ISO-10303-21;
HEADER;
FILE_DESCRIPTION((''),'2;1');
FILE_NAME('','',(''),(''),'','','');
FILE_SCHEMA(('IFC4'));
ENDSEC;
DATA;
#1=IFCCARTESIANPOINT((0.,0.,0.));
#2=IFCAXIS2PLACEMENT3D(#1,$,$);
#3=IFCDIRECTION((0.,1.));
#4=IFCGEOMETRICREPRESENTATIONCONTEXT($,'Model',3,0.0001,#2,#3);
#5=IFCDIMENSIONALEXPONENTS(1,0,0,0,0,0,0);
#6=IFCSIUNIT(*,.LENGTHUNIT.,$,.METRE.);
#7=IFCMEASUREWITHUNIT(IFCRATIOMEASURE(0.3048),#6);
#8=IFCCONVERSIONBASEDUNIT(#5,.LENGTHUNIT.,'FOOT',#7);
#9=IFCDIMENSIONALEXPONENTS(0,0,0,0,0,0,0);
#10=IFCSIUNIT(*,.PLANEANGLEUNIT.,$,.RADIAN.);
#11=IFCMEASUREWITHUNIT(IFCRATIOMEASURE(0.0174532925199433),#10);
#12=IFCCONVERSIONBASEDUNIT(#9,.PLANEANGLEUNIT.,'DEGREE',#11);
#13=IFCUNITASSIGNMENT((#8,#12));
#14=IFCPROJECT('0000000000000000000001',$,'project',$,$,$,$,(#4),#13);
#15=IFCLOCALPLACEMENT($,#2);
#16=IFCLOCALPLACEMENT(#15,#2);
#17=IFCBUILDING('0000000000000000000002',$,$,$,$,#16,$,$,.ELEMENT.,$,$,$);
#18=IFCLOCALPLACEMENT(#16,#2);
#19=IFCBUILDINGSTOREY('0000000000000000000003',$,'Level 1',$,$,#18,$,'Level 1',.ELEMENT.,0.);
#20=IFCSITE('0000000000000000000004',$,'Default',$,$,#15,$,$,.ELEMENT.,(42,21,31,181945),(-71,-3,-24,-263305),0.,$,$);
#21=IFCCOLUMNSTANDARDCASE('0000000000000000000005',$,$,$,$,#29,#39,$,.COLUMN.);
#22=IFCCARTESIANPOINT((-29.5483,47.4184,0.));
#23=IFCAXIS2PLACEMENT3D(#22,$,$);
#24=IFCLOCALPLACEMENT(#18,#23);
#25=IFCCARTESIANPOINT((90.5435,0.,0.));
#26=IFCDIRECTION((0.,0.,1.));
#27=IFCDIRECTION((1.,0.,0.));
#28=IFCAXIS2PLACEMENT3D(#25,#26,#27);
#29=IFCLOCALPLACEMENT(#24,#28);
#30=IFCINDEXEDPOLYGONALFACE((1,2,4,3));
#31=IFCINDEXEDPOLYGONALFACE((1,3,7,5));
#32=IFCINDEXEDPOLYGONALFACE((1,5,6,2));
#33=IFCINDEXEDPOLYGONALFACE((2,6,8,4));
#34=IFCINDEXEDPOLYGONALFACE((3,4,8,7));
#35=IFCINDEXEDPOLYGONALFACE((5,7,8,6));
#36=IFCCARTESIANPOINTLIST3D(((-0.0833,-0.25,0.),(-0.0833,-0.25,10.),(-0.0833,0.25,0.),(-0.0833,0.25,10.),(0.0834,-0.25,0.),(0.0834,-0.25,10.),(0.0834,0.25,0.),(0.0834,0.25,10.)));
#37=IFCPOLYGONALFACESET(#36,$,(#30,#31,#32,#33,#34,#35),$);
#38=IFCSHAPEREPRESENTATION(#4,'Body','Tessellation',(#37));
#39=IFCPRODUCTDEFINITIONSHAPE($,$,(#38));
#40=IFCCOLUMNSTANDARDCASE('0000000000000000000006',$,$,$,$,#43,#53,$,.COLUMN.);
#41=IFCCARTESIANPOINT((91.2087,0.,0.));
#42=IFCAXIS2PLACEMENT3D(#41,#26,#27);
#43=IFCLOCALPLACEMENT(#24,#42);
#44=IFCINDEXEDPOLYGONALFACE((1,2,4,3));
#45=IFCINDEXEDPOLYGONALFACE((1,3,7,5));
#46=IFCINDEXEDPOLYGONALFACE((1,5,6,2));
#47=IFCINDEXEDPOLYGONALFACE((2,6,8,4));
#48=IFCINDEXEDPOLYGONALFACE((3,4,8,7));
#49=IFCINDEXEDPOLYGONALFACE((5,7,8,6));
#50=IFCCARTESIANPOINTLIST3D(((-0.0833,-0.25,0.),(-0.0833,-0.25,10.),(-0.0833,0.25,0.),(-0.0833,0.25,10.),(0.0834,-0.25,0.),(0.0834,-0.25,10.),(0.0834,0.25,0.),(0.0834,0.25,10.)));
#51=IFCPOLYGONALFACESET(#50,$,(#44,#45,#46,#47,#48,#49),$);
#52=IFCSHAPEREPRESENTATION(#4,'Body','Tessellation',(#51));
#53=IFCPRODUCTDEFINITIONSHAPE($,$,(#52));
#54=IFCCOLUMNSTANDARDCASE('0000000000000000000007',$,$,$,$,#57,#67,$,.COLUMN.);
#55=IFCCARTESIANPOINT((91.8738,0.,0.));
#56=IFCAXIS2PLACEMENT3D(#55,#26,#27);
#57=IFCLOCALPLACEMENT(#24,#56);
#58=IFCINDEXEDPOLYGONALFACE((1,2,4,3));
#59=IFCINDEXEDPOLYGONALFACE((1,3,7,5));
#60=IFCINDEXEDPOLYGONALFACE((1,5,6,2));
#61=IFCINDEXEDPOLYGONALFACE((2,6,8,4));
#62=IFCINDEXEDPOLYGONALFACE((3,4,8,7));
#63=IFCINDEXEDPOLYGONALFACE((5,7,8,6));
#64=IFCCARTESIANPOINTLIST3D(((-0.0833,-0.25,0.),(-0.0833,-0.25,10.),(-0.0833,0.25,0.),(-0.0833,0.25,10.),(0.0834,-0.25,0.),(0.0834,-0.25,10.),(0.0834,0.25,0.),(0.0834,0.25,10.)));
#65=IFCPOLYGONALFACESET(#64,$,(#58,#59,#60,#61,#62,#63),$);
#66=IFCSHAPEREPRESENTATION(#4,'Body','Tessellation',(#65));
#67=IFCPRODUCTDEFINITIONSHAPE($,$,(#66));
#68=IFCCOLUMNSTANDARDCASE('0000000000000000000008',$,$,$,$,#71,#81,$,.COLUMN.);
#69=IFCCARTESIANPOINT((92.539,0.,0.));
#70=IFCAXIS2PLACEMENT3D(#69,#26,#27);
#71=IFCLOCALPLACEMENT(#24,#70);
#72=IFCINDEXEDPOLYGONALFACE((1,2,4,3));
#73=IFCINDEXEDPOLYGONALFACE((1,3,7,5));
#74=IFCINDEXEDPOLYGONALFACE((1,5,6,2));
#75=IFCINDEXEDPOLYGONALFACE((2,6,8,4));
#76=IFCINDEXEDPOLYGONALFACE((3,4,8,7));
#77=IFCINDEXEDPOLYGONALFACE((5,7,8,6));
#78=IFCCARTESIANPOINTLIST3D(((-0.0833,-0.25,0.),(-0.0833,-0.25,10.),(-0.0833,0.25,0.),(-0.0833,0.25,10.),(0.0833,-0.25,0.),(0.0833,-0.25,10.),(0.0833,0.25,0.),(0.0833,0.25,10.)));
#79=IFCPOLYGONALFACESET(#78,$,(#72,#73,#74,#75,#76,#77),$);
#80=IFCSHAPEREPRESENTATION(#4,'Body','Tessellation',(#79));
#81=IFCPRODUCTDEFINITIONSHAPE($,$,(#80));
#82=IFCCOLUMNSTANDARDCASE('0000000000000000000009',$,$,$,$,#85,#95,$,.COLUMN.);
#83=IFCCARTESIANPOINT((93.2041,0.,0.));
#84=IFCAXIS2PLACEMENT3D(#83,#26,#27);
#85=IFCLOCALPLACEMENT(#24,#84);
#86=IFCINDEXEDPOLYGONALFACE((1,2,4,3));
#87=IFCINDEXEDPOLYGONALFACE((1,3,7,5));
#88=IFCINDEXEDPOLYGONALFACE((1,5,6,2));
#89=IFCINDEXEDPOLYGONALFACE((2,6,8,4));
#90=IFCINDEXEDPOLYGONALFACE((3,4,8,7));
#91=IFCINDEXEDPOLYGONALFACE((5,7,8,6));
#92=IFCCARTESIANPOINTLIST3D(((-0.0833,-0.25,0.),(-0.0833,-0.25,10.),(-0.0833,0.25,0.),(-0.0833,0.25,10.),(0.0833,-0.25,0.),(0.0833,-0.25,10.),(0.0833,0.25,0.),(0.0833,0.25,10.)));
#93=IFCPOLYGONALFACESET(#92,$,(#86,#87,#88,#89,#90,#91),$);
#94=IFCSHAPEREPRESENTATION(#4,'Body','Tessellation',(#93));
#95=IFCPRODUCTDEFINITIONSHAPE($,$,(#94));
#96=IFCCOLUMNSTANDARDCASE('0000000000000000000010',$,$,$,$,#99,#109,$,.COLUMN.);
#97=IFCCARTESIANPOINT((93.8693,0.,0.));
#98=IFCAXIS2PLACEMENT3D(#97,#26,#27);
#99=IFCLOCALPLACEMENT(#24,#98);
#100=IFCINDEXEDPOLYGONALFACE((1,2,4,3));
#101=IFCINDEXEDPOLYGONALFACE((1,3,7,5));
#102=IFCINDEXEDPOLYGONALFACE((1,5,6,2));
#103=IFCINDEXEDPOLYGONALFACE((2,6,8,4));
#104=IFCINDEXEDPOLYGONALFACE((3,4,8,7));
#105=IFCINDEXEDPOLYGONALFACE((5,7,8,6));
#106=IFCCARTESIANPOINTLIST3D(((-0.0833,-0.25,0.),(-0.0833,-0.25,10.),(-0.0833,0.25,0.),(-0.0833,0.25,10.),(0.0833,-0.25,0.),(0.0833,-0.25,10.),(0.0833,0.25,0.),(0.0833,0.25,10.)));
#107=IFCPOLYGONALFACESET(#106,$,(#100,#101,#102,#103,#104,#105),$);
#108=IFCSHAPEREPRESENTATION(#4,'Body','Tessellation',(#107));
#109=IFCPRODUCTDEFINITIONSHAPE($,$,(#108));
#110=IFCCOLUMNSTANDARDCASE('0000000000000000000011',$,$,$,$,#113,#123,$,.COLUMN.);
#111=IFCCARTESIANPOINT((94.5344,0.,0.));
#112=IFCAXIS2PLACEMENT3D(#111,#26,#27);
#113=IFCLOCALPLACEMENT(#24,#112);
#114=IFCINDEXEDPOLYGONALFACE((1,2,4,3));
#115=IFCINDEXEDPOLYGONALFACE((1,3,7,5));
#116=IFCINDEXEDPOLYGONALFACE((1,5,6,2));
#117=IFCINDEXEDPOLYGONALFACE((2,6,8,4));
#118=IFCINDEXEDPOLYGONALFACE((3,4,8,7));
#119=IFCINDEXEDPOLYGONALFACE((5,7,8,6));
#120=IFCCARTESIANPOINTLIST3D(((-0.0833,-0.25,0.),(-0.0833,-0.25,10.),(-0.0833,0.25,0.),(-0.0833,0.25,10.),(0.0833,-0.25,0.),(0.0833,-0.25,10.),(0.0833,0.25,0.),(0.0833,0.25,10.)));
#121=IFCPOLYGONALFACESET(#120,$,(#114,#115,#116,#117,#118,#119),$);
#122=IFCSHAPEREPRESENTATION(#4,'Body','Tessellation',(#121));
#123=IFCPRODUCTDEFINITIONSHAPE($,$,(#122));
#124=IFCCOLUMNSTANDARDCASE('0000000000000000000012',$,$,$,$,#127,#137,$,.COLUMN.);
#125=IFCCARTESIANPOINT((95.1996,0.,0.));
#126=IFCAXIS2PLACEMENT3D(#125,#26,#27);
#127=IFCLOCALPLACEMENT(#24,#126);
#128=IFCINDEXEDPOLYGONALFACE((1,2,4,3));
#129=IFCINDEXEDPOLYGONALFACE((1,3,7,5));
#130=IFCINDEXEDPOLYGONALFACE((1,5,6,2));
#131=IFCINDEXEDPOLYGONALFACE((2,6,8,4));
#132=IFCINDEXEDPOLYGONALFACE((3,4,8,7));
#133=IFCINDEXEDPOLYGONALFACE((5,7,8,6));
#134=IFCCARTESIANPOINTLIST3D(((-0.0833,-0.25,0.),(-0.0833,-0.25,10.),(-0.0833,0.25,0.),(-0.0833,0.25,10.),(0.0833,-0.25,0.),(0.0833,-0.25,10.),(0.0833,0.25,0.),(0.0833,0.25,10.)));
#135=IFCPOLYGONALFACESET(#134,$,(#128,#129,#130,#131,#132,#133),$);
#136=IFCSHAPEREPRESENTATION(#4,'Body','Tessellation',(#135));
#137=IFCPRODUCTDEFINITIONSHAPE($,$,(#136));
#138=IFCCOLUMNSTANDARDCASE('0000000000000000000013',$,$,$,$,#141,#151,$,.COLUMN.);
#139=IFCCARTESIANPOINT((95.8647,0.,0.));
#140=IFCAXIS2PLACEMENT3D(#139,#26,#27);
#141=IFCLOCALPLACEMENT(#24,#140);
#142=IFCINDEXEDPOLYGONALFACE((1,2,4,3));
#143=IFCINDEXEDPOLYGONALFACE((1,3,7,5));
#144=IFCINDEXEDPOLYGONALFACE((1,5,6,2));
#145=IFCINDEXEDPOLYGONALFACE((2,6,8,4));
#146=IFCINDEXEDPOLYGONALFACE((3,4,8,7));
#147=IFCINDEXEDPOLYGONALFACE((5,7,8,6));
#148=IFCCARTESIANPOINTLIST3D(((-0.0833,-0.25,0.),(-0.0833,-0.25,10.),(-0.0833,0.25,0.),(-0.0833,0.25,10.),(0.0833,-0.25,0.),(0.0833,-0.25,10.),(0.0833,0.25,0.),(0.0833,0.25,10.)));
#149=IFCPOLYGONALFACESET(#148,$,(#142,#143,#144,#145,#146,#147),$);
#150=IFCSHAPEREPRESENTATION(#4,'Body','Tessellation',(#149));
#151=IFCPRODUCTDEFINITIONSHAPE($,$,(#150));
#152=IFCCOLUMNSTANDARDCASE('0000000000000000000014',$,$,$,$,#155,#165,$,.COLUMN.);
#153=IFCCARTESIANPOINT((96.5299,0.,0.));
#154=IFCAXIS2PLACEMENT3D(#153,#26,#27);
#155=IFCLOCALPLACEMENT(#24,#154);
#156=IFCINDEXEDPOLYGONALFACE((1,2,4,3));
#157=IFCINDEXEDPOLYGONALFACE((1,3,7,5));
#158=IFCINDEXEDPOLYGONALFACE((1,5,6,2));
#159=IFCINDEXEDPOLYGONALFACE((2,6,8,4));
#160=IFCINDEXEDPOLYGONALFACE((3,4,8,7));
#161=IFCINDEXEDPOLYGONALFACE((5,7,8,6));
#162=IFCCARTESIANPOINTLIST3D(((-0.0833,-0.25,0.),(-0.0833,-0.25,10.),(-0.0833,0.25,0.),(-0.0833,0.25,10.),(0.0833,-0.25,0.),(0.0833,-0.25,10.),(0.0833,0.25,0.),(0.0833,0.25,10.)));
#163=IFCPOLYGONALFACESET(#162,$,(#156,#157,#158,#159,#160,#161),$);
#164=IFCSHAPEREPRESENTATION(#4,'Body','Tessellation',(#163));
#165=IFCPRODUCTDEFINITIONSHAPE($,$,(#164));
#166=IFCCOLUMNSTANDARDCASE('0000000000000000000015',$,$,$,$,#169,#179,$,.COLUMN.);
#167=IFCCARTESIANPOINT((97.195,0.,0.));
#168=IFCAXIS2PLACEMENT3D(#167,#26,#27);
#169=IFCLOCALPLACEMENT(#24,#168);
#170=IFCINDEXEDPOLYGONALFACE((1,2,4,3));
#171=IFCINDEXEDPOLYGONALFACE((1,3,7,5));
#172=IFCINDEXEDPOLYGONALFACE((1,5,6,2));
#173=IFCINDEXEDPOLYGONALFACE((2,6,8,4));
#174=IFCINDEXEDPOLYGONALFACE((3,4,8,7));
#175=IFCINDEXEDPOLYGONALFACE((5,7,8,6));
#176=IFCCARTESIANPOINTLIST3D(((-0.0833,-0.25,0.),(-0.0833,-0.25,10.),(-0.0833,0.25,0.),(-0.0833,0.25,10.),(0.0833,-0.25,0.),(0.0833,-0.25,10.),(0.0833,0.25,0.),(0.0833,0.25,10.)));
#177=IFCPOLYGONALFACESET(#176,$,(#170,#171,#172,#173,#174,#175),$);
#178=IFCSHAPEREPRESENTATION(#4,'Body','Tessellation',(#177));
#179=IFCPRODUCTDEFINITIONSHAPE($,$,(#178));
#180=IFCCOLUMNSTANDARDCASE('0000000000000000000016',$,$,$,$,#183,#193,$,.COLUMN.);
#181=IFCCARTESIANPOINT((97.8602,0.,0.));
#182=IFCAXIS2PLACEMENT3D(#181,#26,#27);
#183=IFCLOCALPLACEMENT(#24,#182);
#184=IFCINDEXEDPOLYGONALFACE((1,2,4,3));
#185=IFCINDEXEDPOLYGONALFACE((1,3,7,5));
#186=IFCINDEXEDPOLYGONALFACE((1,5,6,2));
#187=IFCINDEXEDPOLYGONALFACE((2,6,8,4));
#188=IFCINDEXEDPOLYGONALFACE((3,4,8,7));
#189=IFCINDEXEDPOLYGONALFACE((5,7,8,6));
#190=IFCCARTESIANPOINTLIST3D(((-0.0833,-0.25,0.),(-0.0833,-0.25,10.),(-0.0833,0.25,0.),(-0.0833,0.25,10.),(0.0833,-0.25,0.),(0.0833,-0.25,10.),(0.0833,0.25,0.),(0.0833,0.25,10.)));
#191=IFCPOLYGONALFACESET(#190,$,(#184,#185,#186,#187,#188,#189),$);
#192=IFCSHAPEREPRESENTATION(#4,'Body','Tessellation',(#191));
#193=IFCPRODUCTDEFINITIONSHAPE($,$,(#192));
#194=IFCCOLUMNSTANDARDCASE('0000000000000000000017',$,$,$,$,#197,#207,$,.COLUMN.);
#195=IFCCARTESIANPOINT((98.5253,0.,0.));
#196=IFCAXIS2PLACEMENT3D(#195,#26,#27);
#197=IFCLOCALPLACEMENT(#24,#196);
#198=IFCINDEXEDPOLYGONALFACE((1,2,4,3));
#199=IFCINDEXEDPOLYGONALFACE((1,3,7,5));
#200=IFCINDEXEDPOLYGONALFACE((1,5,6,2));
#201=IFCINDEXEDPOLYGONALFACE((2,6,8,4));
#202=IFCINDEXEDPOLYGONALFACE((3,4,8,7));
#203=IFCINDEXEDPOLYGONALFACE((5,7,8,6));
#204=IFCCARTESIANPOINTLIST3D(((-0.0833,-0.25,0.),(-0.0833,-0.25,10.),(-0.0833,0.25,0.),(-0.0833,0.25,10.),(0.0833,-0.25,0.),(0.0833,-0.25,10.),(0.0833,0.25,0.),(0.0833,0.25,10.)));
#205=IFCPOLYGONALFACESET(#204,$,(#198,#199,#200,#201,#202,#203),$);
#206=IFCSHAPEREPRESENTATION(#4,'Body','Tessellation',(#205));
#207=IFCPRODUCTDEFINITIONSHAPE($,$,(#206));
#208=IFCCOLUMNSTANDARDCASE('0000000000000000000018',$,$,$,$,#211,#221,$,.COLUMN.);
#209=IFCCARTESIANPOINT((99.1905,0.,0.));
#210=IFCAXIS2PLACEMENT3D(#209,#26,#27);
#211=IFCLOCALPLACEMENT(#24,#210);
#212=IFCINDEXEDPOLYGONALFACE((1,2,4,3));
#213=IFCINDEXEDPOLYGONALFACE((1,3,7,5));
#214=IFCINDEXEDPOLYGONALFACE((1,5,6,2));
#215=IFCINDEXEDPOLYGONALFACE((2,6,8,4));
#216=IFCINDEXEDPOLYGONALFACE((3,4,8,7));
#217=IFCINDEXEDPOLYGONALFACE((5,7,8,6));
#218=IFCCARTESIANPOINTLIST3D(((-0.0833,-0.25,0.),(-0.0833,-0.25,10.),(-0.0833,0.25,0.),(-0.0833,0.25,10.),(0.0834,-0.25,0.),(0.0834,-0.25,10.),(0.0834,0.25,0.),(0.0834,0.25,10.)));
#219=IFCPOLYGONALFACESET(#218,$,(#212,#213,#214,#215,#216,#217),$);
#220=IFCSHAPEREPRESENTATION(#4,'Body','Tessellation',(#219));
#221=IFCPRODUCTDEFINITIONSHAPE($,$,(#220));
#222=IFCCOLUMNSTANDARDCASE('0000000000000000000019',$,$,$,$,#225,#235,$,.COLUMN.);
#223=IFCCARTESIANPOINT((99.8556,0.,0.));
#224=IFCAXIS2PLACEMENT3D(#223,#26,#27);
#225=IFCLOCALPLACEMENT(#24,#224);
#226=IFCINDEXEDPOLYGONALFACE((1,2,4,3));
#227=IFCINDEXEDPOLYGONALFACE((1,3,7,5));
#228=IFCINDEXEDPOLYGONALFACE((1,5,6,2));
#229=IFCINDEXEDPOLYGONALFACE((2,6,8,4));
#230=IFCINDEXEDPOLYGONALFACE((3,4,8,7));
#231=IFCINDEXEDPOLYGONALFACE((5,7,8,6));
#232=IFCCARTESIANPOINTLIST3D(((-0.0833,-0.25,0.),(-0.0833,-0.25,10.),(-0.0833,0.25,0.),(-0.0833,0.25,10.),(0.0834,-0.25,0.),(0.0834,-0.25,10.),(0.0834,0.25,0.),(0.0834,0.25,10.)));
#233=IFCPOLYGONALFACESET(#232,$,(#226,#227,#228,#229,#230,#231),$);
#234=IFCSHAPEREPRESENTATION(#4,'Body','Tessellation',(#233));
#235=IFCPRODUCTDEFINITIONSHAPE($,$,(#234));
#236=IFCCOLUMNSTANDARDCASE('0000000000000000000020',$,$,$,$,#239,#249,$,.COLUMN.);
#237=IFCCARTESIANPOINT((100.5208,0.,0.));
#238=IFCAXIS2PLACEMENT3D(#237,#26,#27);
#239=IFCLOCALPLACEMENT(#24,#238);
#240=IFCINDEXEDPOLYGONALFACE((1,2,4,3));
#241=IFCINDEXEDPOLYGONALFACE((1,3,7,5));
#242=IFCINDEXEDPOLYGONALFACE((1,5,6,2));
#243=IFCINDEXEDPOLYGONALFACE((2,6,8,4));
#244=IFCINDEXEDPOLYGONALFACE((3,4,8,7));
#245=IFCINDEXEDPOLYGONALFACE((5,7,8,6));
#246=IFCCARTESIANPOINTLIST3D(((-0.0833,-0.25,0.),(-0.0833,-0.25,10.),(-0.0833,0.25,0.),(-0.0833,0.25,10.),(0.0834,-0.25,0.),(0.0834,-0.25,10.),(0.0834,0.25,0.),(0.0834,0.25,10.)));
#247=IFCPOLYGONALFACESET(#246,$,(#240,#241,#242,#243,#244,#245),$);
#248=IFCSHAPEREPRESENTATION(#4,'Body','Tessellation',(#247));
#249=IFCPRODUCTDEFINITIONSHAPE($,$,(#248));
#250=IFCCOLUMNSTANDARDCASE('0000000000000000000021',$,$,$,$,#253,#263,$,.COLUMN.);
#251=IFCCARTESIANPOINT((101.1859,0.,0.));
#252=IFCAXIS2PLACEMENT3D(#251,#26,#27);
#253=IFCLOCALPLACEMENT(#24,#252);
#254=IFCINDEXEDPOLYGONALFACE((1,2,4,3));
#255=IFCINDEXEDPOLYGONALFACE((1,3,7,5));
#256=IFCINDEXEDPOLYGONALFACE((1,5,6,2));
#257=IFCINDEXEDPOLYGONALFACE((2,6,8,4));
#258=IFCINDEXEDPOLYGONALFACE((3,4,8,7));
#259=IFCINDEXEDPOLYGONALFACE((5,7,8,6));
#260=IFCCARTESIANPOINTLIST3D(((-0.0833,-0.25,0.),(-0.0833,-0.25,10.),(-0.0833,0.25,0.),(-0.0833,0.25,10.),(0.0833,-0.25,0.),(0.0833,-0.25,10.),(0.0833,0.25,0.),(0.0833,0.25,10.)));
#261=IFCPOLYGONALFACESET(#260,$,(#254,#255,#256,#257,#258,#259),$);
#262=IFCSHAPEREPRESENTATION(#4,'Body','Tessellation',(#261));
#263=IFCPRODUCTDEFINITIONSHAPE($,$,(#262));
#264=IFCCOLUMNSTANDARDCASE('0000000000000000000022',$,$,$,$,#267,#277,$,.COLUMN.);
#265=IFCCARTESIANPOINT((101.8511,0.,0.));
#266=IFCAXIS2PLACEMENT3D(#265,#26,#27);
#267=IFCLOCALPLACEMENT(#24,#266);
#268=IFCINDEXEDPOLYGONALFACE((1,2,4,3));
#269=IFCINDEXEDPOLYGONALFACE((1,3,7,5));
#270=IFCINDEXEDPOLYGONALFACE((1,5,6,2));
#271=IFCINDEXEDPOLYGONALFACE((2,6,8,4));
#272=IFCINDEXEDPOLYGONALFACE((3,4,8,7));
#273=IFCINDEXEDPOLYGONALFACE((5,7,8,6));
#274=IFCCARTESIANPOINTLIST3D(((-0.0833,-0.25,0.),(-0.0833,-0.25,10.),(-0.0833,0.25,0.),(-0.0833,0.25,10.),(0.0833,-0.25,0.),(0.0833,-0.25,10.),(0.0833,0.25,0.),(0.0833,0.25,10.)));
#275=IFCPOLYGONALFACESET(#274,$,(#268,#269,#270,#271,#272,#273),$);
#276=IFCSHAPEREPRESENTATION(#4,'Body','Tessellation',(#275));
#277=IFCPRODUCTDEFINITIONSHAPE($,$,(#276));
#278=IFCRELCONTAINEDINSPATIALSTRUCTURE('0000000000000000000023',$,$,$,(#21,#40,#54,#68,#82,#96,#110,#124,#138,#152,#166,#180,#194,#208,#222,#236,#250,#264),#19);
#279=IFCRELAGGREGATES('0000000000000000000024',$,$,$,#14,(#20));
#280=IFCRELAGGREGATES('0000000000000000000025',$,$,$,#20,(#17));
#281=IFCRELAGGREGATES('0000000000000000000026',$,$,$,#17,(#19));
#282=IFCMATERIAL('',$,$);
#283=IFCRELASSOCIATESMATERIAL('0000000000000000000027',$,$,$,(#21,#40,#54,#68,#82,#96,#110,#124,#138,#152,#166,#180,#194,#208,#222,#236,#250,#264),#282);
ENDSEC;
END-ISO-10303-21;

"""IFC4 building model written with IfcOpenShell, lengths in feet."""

from ifc_helpers import new_model, entity, si_unit, converted_unit, direction, frame, origin, place, context, project, spatial, rectangle, extrude, material, element, save


model = new_model("IFC4")

# Units and contexts
model_context = context("Model", 3, precision=0.0001, world=origin(), true_north=direction((0.0, 1.0)))
ifc_project = project(units=[converted_unit("LENGTHUNIT", "FOOT", entity("IfcRatioMeasure", 0.3048), si_unit("LENGTHUNIT", "METRE"), dimensions=[1, 0, 0, 0, 0, 0, 0]), converted_unit("PLANEANGLEUNIT", "DEGREE", entity("IfcRatioMeasure", 0.0174532925199433), si_unit("PLANEANGLEUNIT", "RADIAN"), dimensions=[0, 0, 0, 0, 0, 0, 0])], contexts=[model_context])

# Site, building, storey
site_placement = place(None, origin())
site = spatial("IfcSite", under=ifc_project, at=site_placement, Name="Default", CompositionType="ELEMENT", RefLatitude=(42, 21, 31, 181945), RefLongitude=(-71, -3, -24, -263305), RefElevation=0.0)
building_placement = place(site_placement, origin())
building = spatial("IfcBuilding", under=site, at=building_placement, CompositionType="ELEMENT")
storey_placement = place(building_placement, origin())
storey = spatial("IfcBuildingStorey", under=building, at=storey_placement, Name="Level 1", LongName="Level 1", CompositionType="ELEMENT", Elevation=0.0)

# Columns
ifc_material_1 = material(Name="")
placement = place(storey_placement, frame((-29.5483, 47.4184, 0.0)))
for number, where, z_axis, x_axis in (
    (1, (90.5435, 0.0, 0.0), (0.0, 0.0, 1.0), (1.0, 0.0, 0.0)),
    (2, (91.2087, 0.0, 0.0), (0.0, 0.0, 1.0), (1.0, 0.0, 0.0)),
    (3, (91.8738, 0.0, 0.0), (0.0, 0.0, 1.0), (1.0, 0.0, 0.0)),
    (4, (92.539, 0.0, 0.0), (0.0, 0.0, 1.0), (1.0, 0.0, 0.0)),
    (5, (93.2041, 0.0, 0.0), (0.0, 0.0, 1.0), (1.0, 0.0, 0.0)),
    (6, (93.8693, 0.0, 0.0), (0.0, 0.0, 1.0), (1.0, 0.0, 0.0)),
    (7, (94.5344, 0.0, 0.0), (0.0, 0.0, 1.0), (1.0, 0.0, 0.0)),
    (8, (95.1996, 0.0, 0.0), (0.0, 0.0, 1.0), (1.0, 0.0, 0.0)),
    (9, (95.8647, 0.0, 0.0), (0.0, 0.0, 1.0), (1.0, 0.0, 0.0)),
    (10, (96.5299, 0.0, 0.0), (0.0, 0.0, 1.0), (1.0, 0.0, 0.0)),
    (11, (97.195, 0.0, 0.0), (0.0, 0.0, 1.0), (1.0, 0.0, 0.0)),
    (12, (97.8602, 0.0, 0.0), (0.0, 0.0, 1.0), (1.0, 0.0, 0.0)),
    (13, (98.5253, 0.0, 0.0), (0.0, 0.0, 1.0), (1.0, 0.0, 0.0)),
    (14, (99.1905, 0.0, 0.0), (0.0, 0.0, 1.0), (1.0, 0.0, 0.0)),
    (15, (99.8556, 0.0, 0.0), (0.0, 0.0, 1.0), (1.0, 0.0, 0.0)),
    (16, (100.5208, 0.0, 0.0), (0.0, 0.0, 1.0), (1.0, 0.0, 0.0)),
    (17, (101.1859, 0.0, 0.0), (0.0, 0.0, 1.0), (1.0, 0.0, 0.0)),
    (18, (101.8511, 0.0, 0.0), (0.0, 0.0, 1.0), (1.0, 0.0, 0.0)),
):
    element("IfcColumnStandardCase", number, at=place(placement, frame(where, z_axis=z_axis, x_axis=x_axis)), inside=storey, material=ifc_material_1, PredefinedType="COLUMN", context=model_context, shape_type="SweptSolid", body=[
        extrude(rectangle(XDim=0.1667, YDim=0.5), origin(), (0.0, 0.0, 1.0), 10.0),
    ])

save(model, "model.ifc")
